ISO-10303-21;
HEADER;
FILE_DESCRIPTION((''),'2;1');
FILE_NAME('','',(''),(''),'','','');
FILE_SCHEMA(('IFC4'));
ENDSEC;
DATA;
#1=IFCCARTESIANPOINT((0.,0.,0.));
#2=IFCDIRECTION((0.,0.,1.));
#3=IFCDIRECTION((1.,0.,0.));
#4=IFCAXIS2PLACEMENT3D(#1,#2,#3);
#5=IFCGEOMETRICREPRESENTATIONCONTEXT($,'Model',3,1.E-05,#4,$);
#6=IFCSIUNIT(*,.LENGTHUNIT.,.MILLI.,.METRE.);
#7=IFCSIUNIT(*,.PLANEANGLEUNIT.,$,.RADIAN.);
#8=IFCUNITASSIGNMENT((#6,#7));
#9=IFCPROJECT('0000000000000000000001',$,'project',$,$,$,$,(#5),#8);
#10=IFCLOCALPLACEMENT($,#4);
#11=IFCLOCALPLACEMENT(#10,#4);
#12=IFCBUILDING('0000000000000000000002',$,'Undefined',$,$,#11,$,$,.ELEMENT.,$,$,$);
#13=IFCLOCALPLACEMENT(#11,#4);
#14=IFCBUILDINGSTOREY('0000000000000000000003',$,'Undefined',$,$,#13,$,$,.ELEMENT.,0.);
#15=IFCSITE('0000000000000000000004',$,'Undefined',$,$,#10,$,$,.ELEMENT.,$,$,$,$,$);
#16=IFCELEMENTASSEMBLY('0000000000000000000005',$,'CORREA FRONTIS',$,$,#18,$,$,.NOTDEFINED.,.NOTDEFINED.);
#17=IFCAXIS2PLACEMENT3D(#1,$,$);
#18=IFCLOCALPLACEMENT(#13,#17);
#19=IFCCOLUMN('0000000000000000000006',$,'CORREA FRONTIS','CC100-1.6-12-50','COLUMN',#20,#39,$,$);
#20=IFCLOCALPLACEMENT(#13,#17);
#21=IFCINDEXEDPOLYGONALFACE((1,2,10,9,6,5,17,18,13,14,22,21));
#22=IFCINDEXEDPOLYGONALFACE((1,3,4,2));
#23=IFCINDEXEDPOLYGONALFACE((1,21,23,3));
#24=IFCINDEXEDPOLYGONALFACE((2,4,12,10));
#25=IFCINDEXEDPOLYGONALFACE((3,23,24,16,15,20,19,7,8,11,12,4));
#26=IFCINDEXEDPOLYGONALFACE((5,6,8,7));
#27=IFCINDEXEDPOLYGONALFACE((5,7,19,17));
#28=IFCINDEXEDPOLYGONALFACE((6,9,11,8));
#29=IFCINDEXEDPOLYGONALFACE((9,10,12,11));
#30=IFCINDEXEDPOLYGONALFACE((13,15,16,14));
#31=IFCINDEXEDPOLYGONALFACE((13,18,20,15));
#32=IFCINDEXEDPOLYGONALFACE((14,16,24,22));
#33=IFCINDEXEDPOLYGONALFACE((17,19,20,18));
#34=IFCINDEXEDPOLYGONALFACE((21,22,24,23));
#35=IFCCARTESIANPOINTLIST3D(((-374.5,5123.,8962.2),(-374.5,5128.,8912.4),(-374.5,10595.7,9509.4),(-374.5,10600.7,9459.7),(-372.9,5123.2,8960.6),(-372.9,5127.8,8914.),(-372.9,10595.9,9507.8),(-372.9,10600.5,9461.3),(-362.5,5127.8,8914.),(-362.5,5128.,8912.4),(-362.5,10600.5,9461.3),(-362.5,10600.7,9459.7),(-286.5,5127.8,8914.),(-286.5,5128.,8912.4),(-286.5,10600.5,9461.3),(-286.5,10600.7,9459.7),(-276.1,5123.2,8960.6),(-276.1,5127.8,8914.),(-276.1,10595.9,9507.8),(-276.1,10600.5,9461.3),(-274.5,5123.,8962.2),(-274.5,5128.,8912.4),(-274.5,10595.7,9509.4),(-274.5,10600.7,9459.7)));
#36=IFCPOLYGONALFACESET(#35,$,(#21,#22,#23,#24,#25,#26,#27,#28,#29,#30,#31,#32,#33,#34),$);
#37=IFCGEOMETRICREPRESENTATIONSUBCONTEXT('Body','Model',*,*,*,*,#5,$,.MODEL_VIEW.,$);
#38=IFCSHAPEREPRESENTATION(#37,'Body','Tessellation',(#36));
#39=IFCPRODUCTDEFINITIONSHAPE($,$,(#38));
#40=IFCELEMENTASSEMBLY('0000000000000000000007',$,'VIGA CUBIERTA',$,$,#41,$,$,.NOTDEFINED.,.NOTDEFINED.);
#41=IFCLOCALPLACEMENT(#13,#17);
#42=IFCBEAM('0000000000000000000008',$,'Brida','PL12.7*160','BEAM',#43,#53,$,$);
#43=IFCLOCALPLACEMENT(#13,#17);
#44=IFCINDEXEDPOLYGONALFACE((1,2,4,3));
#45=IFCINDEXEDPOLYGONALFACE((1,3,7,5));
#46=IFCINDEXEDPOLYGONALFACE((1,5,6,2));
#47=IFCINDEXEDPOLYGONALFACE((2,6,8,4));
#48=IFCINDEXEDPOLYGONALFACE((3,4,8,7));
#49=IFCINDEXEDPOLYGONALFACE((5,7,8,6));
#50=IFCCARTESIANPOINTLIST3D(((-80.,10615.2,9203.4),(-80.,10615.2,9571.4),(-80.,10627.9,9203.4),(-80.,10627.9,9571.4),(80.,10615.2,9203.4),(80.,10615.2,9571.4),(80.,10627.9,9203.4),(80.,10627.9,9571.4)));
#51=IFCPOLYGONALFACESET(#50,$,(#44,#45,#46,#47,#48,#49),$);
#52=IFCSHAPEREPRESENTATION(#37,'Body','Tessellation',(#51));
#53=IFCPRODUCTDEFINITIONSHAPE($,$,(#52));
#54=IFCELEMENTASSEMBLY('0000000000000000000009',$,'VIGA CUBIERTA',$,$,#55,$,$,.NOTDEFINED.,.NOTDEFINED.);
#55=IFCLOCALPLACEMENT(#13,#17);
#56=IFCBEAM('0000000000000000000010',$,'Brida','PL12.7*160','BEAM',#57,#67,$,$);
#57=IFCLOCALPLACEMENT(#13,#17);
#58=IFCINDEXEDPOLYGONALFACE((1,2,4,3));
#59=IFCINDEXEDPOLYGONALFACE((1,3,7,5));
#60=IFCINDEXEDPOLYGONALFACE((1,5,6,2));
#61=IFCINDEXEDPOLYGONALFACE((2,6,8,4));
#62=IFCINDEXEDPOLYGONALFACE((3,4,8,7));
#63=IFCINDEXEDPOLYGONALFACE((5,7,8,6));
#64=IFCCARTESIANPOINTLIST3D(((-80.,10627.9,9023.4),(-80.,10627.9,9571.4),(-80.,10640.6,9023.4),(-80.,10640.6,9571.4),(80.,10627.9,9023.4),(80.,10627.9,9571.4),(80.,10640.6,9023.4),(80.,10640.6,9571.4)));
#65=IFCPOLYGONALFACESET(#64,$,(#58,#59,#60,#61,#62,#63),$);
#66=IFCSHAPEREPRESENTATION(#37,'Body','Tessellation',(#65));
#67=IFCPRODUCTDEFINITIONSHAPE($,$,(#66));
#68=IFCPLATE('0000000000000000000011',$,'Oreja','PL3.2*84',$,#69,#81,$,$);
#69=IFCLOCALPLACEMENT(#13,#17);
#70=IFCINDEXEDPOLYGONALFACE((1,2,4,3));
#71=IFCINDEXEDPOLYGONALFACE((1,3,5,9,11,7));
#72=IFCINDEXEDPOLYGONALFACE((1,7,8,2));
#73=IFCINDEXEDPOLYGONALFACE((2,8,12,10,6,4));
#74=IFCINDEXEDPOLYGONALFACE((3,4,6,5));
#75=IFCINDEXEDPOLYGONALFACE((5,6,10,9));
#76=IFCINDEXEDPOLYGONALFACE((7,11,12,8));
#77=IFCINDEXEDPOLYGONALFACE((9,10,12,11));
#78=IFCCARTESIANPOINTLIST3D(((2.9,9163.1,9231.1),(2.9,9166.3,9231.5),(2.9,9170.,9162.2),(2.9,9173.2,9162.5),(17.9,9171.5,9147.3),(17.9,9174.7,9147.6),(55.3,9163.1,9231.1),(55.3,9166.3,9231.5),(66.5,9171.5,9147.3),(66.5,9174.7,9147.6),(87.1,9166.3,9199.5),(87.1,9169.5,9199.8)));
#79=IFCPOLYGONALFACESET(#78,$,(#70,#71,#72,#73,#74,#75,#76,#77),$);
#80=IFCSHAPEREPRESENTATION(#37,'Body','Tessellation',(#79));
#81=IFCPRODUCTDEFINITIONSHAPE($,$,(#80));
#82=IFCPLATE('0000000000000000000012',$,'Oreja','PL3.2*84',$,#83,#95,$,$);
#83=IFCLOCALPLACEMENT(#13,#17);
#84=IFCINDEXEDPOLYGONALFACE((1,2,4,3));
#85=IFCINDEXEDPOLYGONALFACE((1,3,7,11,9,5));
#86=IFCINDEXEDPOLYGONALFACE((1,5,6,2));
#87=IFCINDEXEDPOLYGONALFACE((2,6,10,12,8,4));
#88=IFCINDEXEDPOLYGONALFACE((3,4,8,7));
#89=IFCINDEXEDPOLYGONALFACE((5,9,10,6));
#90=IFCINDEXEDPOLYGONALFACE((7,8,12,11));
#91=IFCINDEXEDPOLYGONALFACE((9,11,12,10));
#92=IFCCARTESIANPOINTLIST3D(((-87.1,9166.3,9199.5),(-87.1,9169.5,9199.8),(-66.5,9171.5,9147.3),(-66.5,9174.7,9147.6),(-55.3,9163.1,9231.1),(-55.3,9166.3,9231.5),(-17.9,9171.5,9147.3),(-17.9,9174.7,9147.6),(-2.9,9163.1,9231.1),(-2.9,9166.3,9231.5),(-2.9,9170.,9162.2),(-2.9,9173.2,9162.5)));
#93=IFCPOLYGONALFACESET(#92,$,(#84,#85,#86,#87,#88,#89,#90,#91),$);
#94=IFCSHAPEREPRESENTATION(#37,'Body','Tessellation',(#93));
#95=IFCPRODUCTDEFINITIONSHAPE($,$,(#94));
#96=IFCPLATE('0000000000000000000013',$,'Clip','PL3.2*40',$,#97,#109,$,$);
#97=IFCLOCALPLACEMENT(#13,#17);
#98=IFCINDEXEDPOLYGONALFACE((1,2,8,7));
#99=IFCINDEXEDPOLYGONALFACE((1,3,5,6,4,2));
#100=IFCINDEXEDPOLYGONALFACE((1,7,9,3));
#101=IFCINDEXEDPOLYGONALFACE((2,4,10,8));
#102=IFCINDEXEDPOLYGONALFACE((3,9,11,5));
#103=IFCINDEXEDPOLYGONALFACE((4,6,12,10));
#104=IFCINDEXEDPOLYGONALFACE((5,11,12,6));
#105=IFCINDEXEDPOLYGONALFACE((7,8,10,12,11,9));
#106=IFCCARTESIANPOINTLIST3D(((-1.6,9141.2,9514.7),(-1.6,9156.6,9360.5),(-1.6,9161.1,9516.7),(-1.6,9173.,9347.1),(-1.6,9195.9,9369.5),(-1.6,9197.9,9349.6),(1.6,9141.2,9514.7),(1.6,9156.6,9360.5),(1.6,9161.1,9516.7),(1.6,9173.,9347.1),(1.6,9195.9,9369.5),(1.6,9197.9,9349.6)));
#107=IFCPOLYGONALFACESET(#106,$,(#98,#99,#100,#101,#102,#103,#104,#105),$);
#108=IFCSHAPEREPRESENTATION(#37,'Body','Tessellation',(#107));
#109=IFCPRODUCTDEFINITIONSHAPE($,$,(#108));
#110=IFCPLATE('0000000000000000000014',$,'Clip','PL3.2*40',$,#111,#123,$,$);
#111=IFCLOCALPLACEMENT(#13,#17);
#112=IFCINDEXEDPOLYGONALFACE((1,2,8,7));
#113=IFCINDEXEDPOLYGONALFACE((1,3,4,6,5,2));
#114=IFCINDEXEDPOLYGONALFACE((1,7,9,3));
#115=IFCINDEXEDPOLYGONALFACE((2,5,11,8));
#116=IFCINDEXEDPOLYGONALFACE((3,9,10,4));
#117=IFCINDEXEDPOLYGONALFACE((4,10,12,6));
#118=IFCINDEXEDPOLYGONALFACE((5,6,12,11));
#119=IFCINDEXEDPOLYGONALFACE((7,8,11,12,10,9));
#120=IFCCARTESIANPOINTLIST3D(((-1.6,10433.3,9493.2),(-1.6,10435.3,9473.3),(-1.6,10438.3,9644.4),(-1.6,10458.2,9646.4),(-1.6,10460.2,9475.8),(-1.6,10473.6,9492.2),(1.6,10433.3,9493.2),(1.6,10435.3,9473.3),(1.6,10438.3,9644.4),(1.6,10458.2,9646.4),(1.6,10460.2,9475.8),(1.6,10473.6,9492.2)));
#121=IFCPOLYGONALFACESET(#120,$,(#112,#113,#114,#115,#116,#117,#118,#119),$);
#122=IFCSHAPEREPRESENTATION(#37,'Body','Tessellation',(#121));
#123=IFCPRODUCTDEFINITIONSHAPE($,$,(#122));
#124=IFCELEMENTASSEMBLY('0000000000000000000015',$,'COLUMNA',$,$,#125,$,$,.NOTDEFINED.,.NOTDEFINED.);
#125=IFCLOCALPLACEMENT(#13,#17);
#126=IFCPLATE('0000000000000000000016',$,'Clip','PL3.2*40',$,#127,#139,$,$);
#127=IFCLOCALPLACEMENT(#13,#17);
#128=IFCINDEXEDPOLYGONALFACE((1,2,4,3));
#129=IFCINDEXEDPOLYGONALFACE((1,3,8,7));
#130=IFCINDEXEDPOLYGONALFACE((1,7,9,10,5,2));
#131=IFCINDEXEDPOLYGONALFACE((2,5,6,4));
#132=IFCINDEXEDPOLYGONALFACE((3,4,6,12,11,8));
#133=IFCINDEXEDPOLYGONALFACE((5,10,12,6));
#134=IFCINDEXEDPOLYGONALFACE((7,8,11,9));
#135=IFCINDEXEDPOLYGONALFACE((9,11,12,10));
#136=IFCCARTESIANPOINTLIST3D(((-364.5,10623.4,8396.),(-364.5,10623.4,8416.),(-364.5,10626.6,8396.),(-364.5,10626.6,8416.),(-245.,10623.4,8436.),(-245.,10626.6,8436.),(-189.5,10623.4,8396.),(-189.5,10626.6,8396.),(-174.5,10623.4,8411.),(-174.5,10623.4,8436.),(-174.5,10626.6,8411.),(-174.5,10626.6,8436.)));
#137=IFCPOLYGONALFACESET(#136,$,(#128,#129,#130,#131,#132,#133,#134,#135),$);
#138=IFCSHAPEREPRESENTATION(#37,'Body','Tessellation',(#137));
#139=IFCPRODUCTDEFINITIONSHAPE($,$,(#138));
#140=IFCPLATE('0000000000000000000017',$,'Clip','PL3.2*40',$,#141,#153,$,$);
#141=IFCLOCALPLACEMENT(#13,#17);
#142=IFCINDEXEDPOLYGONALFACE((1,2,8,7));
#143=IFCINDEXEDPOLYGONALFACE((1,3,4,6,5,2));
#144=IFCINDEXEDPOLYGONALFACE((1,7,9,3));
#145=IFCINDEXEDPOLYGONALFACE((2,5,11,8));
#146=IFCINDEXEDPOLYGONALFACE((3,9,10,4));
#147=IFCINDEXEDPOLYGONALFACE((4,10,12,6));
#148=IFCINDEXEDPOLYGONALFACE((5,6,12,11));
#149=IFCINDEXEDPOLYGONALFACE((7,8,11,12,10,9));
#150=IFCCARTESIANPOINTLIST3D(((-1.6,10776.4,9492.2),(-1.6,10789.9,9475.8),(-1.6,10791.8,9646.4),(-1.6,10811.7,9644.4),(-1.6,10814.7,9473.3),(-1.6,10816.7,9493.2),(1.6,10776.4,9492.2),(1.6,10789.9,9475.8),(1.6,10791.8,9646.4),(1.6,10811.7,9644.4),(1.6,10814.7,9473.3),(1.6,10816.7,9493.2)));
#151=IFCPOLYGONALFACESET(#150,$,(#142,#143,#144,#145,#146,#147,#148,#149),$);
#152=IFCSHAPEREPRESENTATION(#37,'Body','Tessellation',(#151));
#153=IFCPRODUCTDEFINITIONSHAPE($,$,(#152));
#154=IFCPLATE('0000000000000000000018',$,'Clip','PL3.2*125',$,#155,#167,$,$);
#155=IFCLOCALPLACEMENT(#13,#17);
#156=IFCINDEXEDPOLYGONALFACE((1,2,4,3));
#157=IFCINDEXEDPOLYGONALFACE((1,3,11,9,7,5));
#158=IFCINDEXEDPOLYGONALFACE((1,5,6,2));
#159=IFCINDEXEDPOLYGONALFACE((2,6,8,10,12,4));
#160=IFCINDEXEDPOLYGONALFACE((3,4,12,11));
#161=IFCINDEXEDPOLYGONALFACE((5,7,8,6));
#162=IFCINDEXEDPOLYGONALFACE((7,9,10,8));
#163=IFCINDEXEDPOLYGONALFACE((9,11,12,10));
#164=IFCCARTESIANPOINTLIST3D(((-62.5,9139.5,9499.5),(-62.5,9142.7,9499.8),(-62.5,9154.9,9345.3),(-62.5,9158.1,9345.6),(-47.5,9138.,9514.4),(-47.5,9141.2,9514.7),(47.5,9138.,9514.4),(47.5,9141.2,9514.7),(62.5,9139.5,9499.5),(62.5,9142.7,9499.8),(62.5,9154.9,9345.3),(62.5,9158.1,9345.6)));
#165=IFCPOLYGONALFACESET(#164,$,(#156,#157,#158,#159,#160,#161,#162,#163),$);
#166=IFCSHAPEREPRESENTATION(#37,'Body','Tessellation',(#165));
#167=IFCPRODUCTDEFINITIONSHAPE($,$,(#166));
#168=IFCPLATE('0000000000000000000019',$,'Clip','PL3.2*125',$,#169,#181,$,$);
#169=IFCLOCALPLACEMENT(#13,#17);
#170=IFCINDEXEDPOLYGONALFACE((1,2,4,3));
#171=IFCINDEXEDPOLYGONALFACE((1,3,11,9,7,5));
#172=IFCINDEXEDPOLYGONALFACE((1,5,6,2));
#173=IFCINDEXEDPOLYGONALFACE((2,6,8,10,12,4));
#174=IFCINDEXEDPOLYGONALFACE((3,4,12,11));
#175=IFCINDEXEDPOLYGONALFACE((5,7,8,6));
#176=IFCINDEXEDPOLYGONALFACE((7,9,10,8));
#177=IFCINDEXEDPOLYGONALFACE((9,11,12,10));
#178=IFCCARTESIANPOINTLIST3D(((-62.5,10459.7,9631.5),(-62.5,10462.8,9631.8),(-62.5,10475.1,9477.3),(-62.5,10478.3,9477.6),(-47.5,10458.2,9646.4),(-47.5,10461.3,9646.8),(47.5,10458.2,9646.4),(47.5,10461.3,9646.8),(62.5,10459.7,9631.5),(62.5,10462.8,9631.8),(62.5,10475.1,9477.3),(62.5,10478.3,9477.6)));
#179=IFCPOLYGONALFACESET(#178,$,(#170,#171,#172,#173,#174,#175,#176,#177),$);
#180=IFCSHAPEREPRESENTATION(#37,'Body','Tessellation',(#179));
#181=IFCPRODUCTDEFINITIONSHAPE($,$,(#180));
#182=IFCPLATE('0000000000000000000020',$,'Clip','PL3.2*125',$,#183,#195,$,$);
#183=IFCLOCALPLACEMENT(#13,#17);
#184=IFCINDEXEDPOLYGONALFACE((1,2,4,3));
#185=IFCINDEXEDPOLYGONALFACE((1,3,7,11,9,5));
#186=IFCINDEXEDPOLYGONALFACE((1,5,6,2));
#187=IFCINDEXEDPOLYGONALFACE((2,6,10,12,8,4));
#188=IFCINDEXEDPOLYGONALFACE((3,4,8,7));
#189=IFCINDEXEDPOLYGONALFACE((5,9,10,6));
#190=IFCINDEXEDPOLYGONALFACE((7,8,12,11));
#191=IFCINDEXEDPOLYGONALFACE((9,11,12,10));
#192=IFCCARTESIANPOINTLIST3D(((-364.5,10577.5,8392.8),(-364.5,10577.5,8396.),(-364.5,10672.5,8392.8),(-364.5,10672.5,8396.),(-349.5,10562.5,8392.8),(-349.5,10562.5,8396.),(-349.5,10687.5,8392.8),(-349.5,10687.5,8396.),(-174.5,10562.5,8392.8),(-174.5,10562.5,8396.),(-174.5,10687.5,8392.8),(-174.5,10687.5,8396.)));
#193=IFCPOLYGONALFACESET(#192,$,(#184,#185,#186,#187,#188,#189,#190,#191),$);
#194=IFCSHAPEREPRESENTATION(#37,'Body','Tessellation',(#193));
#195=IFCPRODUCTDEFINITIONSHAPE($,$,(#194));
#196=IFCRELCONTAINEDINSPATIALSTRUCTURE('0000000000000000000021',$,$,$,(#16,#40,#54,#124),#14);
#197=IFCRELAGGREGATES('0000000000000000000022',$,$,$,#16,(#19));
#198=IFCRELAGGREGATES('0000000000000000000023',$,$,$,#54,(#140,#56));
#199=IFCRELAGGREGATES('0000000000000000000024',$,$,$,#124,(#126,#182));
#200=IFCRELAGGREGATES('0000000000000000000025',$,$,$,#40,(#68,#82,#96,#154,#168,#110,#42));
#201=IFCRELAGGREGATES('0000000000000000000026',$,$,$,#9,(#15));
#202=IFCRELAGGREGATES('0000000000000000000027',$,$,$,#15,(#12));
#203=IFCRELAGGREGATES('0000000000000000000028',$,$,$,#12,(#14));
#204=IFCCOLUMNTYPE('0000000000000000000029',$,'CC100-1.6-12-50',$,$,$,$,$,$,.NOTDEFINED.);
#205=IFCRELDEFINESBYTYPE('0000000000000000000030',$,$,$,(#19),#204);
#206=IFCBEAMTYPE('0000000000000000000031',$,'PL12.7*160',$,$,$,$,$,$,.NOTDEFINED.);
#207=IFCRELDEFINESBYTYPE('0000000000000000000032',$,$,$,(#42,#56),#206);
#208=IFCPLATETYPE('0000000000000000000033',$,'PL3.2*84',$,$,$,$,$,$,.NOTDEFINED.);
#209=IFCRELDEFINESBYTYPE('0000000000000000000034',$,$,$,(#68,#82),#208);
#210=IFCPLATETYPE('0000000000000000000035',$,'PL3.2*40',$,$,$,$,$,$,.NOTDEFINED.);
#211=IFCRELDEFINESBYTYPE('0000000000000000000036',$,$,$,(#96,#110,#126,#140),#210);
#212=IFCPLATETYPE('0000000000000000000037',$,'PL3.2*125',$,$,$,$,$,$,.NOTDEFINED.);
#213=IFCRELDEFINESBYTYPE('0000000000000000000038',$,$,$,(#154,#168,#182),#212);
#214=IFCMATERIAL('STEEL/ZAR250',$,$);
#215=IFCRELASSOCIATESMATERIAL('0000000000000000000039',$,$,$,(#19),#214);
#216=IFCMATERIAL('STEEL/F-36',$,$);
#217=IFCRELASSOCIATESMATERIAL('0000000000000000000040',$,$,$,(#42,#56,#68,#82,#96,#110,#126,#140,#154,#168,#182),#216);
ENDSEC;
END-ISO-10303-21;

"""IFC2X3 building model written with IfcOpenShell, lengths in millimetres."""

from ifc_helpers import new_model, si_unit, frame, origin_with_axes, origin_2d_with_axis, place, context, subcontext, project, spatial, polyline, rectangle, c_section, outline, extrude, material, type_object, element, aggregate, save


model = new_model("IFC2X3")

# Units and contexts
model_context = context("Model", 3, precision=1e-05, world=origin_with_axes())
body_context = subcontext(model_context, "Body", "Model", "MODEL_VIEW")
ifc_project = project(units=[si_unit("LENGTHUNIT", "METRE", prefix="MILLI"), si_unit("PLANEANGLEUNIT", "RADIAN")], contexts=[model_context])

# Site, building, storey
site_placement = place(None, origin_with_axes())
site = spatial("IfcSite", under=ifc_project, at=site_placement, Name="Undefined", CompositionType="ELEMENT")
building_placement = place(site_placement, origin_with_axes())
building = spatial("IfcBuilding", under=site, at=building_placement, Name="Undefined", CompositionType="ELEMENT")
storey_placement = place(building_placement, origin_with_axes())
storey = spatial("IfcBuildingStorey", under=building, at=storey_placement, Name="Undefined", CompositionType="ELEMENT", Elevation=0.0)

# Element assembly, column
assembly_1_placement = place(storey_placement, origin_with_axes())
assembly_1 = element("IfcElementAssembly", 1, at=assembly_1_placement, inside=storey, Name="CORREA FRONTIS", AssemblyPlace="NOTDEFINED", PredefinedType="NOTDEFINED")
ifc_material_1 = material(Name="STEEL/ZAR250")
column_type = type_object("IfcColumnType", Name="CC100-1.6-12-50", PredefinedType="NOTDEFINED")
column_placement = place(assembly_1_placement, frame((-324.5, 10598.2, 9484.6), z_axis=(0.0, -0.995037, -0.099504), x_axis=(-1.0, 0.0, 0.0)))
column = element("IfcColumn", 2, at=column_placement, type_object=column_type, material=ifc_material_1, Name="CORREA FRONTIS", Description="CC100-1.6-12-50", ObjectType="COLUMN", context=body_context, shape_type="SweptSolid", body=[
    extrude(c_section(Depth=100.0, Width=50.0, WallThickness=1.6, Girth=12.0, at=origin_2d_with_axis()), frame((0.0, 0.0, 5500.0), z_axis=(0.0, 0.0, -1.0), x_axis=(0.0, 1.0, 0.0)), (0.0, 0.0, 1.0), 5500.0),
])
aggregate(assembly_1, [column])

# Element assemblies, beams
assembly_2_placement = place(storey_placement, origin_with_axes())
assembly_2 = element("IfcElementAssembly", 3, at=assembly_2_placement, inside=storey, Name="VIGA CUBIERTA", AssemblyPlace="NOTDEFINED", PredefinedType="NOTDEFINED")
ifc_material_2 = material(Name="STEEL/F-36")
beam_type = type_object("IfcBeamType", Name="PL12.7*160", PredefinedType="NOTDEFINED")
beam_1_placement = place(assembly_2_placement, frame((0.0, 10621.6, 9571.4), z_axis=(-1.0, 0.0, 0.0), x_axis=(0.0, 0.0, -1.0)))
beam_1 = element("IfcBeam", 4, at=beam_1_placement, type_object=beam_type, material=ifc_material_2, Name="Brida", Description="PL12.7*160", ObjectType="BEAM", context=body_context, shape_type="SweptSolid", body=[
    extrude(rectangle(XDim=12.7, YDim=160.0, at=origin_2d_with_axis()), frame((368.0, 0.0, 0.0), z_axis=(-1.0, 0.0, 0.0), x_axis=(0.0, -1.0, 0.0)), (0.0, 0.0, 1.0), 368.0),
])
assembly_3_placement = place(storey_placement, origin_with_axes())
assembly_3 = element("IfcElementAssembly", 5, at=assembly_3_placement, inside=storey, Name="VIGA CUBIERTA", AssemblyPlace="NOTDEFINED", PredefinedType="NOTDEFINED")
beam_2_placement = place(assembly_3_placement, frame((0.0, 10634.3, 9571.4), z_axis=(-1.0, 0.0, 0.0), x_axis=(0.0, 0.0, -1.0)))
beam_2 = element("IfcBeam", 6, at=beam_2_placement, type_object=beam_type, material=ifc_material_2, Name="Brida", Description="PL12.7*160", ObjectType="BEAM", context=body_context, shape_type="SweptSolid", body=[
    extrude(rectangle(XDim=12.7, YDim=160.0, at=origin_2d_with_axis()), frame((548.0, 0.0, 0.0), z_axis=(-1.0, 0.0, 0.0), x_axis=(0.0, -1.0, 0.0)), (0.0, 0.0, 1.0), 548.0),
])

# Plates
plate_type_1 = type_object("IfcPlateType", Name="PL3.2*84", PredefinedType="NOTDEFINED")
plate_1_placement = place(assembly_2_placement, frame((2.9, 9173.1, 9147.5), z_axis=(0.0, -0.995037, -0.099504), x_axis=(1.0, 0.0, -0.000004)))
plate_1 = element("IfcPlate", 7, at=plate_1_placement, type_object=plate_type_1, material=ifc_material_2, Name="Oreja", Description="PL3.2*84", context=body_context, shape_type="SweptSolid", body=[
    extrude(outline(polyline([(0.0, 15.0), (15.0, 0.0), (63.6, 0.0), (84.2, 52.4), (52.4, 84.2), (0.0, 84.2), (0.0, 15.0)])), frame((0.0, 0.0, -1.6), z_axis=(0.0, 0.0, 1.0), x_axis=(1.0, 0.0, 0.0)), (0.0, 0.0, 1.0), 3.2),
])
plate_2_placement = place(assembly_2_placement, frame((-2.9, 9173.1, 9147.5), z_axis=(0.0, 0.995037, 0.099504), x_axis=(-1.0, 0.000001, -0.000004)))
plate_2 = element("IfcPlate", 8, at=plate_2_placement, type_object=plate_type_1, material=ifc_material_2, Name="Oreja", Description="PL3.2*84", context=body_context, shape_type="SweptSolid", body=[
    extrude(outline(polyline([(0.0, 15.0), (15.0, 0.0), (63.6, 0.0), (84.2, 52.4), (52.4, 84.2), (0.0, 84.2), (0.0, 15.0)])), frame((0.0, 0.0, -1.6), z_axis=(0.0, 0.0, 1.0), x_axis=(1.0, 0.0, 0.0)), (0.0, 0.0, 1.0), 3.2),
])
plate_type_2 = type_object("IfcPlateType", Name="PL3.2*40", PredefinedType="NOTDEFINED")
plate_3_placement = place(assembly_2_placement, frame((0.0, 9197.9, 9349.6), z_axis=(-1.0, 0.0, 0.0), x_axis=(0.0, -0.995037, -0.099504)))
plate_3 = element("IfcPlate", 9, at=plate_3_placement, type_object=plate_type_2, material=ifc_material_2, Name="Clip", Description="PL3.2*40", context=body_context, shape_type="SweptSolid", body=[
    extrude(outline(polyline([(0.0, 0.0), (25.0, 0.0), (40.0, 15.0), (40.0, 170.0), (20.0, 170.0), (0.0, 20.0), (0.0, 0.0)])), frame((0.0, 0.0, -1.6), z_axis=(0.0, 0.0, 1.0), x_axis=(1.0, 0.0, 0.0)), (0.0, 0.0, 1.0), 3.2),
])
plate_4_placement = place(assembly_2_placement, frame((0.0, 10418.4, 9642.5), z_axis=(-1.0, 0.0, 0.0), x_axis=(0.0, 0.995038, 0.0995)))
plate_4 = element("IfcPlate", 10, at=plate_4_placement, type_object=plate_type_2, material=ifc_material_2, Name="Clip", Description="PL3.2*40", context=body_context, shape_type="SweptSolid", body=[
    extrude(outline(polyline([(0.0, 150.0), (20.0, 0.0), (40.0, 0.0), (40.0, 155.0), (25.0, 170.0), (0.0, 170.0), (0.0, 170.0), (0.0, 150.0)])), frame((0.0, 0.0, -1.6), z_axis=(0.0, 0.0, 1.0), x_axis=(1.0, 0.0, 0.0)), (0.0, 0.0, 1.0), 3.2),
])

# Element assembly, plate
assembly_4_placement = place(storey_placement, origin_with_axes())
assembly_4 = element("IfcElementAssembly", 11, at=assembly_4_placement, inside=storey, Name="COLUMNA", AssemblyPlace="NOTDEFINED", PredefinedType="NOTDEFINED")
plate_5_placement = place(assembly_4_placement, frame((-174.5, 10625.0, 8436.0), z_axis=(0.0, 1.0, 0.0), x_axis=(-0.000007, 0.0, -1.0)))
plate_5 = element("IfcPlate", 12, at=plate_5_placement, type_object=plate_type_2, material=ifc_material_2, Name="Clip", Description="PL3.2*40", context=body_context, shape_type="SweptSolid", body=[
    extrude(outline(polyline([(0.0, 0.0), (25.0, 0.0), (40.0, 15.0), (40.0, 190.0), (20.0, 190.0), (0.0, 70.5), (0.0, 0.0)])), frame((0.0, 0.0, -1.6), z_axis=(0.0, 0.0, 1.0), x_axis=(1.0, 0.0, 0.0)), (0.0, 0.0, 1.0), 3.2),
])

# Plates
plate_6_placement = place(assembly_3_placement, frame((0.0, 10831.6, 9642.5), z_axis=(1.0, 0.0, 0.0), x_axis=(0.0, -0.995038, 0.099501)))
plate_6 = element("IfcPlate", 13, at=plate_6_placement, type_object=plate_type_2, material=ifc_material_2, Name="Clip", Description="PL3.2*40", context=body_context, shape_type="SweptSolid", body=[
    extrude(outline(polyline([(0.0, 150.0), (20.0, 0.0), (40.0, 0.0), (40.0, 155.0), (25.0, 170.0), (0.0, 170.0), (0.0, 170.0), (0.0, 150.0)])), frame((0.0, 0.0, -1.6), z_axis=(0.0, 0.0, 1.0), x_axis=(1.0, 0.0, 0.0)), (0.0, 0.0, 1.0), 3.2),
])
plate_type_3 = type_object("IfcPlateType", Name="PL3.2*125", PredefinedType="NOTDEFINED")
plate_7_placement = place(assembly_2_placement, frame((-62.5, 9156.5, 9345.4), z_axis=(0.0, -0.995037, -0.099504), x_axis=(1.0, 0.0, 0.0)))
plate_7 = element("IfcPlate", 14, at=plate_7_placement, type_object=plate_type_3, material=ifc_material_2, Name="Clip", Description="PL3.2*125", context=body_context, shape_type="SweptSolid", body=[
    extrude(outline(polyline([(0.0, 0.0), (125.0, 0.0), (125.0, 155.0), (110.0, 170.0), (15.0, 170.0), (0.0, 155.0), (0.0, 0.0)])), frame((0.0, 0.0, -1.6), z_axis=(0.0, 0.0, 1.0), x_axis=(1.0, 0.0, 0.0)), (0.0, 0.0, 1.0), 3.2),
])
plate_8_placement = place(assembly_2_placement, frame((62.5, 10476.7, 9477.4), z_axis=(0.0, 0.995037, 0.099504), x_axis=(-1.0, 0.0, 0.0)))
plate_8 = element("IfcPlate", 15, at=plate_8_placement, type_object=plate_type_3, material=ifc_material_2, Name="Clip", Description="PL3.2*125", context=body_context, shape_type="SweptSolid", body=[
    extrude(outline(polyline([(0.0, 0.0), (125.0, 0.0), (125.0, 155.0), (110.0, 170.0), (15.0, 170.0), (0.0, 155.0), (0.0, 0.0)])), frame((0.0, 0.0, -1.6), z_axis=(0.0, 0.0, 1.0), x_axis=(1.0, 0.0, 0.0)), (0.0, 0.0, 1.0), 3.2),
])
plate_9_placement = place(assembly_4_placement, frame((-174.5, 10687.5, 8394.4), z_axis=(0.000007, 0.0, -1.0), x_axis=(0.0, -1.0, 0.0)))
plate_9 = element("IfcPlate", 16, at=plate_9_placement, type_object=plate_type_3, material=ifc_material_2, Name="Clip", Description="PL3.2*125", context=body_context, shape_type="SweptSolid", body=[
    extrude(outline(polyline([(0.0, 0.0), (125.0, 0.0), (125.0, 175.0), (110.0, 190.0), (15.0, 190.0), (0.0, 175.0), (0.0, 0.0)])), frame((0.0, 0.0, -1.6), z_axis=(0.0, 0.0, 1.0), x_axis=(1.0, 0.0, 0.0)), (0.0, 0.0, 1.0), 3.2),
])
aggregate(assembly_3, [plate_6, beam_2])

aggregate(assembly_4, [plate_5, plate_9])
aggregate(assembly_2, [plate_1, plate_2, plate_3, plate_7, plate_8, plate_4, beam_1])

save(model, "model.ifc")
